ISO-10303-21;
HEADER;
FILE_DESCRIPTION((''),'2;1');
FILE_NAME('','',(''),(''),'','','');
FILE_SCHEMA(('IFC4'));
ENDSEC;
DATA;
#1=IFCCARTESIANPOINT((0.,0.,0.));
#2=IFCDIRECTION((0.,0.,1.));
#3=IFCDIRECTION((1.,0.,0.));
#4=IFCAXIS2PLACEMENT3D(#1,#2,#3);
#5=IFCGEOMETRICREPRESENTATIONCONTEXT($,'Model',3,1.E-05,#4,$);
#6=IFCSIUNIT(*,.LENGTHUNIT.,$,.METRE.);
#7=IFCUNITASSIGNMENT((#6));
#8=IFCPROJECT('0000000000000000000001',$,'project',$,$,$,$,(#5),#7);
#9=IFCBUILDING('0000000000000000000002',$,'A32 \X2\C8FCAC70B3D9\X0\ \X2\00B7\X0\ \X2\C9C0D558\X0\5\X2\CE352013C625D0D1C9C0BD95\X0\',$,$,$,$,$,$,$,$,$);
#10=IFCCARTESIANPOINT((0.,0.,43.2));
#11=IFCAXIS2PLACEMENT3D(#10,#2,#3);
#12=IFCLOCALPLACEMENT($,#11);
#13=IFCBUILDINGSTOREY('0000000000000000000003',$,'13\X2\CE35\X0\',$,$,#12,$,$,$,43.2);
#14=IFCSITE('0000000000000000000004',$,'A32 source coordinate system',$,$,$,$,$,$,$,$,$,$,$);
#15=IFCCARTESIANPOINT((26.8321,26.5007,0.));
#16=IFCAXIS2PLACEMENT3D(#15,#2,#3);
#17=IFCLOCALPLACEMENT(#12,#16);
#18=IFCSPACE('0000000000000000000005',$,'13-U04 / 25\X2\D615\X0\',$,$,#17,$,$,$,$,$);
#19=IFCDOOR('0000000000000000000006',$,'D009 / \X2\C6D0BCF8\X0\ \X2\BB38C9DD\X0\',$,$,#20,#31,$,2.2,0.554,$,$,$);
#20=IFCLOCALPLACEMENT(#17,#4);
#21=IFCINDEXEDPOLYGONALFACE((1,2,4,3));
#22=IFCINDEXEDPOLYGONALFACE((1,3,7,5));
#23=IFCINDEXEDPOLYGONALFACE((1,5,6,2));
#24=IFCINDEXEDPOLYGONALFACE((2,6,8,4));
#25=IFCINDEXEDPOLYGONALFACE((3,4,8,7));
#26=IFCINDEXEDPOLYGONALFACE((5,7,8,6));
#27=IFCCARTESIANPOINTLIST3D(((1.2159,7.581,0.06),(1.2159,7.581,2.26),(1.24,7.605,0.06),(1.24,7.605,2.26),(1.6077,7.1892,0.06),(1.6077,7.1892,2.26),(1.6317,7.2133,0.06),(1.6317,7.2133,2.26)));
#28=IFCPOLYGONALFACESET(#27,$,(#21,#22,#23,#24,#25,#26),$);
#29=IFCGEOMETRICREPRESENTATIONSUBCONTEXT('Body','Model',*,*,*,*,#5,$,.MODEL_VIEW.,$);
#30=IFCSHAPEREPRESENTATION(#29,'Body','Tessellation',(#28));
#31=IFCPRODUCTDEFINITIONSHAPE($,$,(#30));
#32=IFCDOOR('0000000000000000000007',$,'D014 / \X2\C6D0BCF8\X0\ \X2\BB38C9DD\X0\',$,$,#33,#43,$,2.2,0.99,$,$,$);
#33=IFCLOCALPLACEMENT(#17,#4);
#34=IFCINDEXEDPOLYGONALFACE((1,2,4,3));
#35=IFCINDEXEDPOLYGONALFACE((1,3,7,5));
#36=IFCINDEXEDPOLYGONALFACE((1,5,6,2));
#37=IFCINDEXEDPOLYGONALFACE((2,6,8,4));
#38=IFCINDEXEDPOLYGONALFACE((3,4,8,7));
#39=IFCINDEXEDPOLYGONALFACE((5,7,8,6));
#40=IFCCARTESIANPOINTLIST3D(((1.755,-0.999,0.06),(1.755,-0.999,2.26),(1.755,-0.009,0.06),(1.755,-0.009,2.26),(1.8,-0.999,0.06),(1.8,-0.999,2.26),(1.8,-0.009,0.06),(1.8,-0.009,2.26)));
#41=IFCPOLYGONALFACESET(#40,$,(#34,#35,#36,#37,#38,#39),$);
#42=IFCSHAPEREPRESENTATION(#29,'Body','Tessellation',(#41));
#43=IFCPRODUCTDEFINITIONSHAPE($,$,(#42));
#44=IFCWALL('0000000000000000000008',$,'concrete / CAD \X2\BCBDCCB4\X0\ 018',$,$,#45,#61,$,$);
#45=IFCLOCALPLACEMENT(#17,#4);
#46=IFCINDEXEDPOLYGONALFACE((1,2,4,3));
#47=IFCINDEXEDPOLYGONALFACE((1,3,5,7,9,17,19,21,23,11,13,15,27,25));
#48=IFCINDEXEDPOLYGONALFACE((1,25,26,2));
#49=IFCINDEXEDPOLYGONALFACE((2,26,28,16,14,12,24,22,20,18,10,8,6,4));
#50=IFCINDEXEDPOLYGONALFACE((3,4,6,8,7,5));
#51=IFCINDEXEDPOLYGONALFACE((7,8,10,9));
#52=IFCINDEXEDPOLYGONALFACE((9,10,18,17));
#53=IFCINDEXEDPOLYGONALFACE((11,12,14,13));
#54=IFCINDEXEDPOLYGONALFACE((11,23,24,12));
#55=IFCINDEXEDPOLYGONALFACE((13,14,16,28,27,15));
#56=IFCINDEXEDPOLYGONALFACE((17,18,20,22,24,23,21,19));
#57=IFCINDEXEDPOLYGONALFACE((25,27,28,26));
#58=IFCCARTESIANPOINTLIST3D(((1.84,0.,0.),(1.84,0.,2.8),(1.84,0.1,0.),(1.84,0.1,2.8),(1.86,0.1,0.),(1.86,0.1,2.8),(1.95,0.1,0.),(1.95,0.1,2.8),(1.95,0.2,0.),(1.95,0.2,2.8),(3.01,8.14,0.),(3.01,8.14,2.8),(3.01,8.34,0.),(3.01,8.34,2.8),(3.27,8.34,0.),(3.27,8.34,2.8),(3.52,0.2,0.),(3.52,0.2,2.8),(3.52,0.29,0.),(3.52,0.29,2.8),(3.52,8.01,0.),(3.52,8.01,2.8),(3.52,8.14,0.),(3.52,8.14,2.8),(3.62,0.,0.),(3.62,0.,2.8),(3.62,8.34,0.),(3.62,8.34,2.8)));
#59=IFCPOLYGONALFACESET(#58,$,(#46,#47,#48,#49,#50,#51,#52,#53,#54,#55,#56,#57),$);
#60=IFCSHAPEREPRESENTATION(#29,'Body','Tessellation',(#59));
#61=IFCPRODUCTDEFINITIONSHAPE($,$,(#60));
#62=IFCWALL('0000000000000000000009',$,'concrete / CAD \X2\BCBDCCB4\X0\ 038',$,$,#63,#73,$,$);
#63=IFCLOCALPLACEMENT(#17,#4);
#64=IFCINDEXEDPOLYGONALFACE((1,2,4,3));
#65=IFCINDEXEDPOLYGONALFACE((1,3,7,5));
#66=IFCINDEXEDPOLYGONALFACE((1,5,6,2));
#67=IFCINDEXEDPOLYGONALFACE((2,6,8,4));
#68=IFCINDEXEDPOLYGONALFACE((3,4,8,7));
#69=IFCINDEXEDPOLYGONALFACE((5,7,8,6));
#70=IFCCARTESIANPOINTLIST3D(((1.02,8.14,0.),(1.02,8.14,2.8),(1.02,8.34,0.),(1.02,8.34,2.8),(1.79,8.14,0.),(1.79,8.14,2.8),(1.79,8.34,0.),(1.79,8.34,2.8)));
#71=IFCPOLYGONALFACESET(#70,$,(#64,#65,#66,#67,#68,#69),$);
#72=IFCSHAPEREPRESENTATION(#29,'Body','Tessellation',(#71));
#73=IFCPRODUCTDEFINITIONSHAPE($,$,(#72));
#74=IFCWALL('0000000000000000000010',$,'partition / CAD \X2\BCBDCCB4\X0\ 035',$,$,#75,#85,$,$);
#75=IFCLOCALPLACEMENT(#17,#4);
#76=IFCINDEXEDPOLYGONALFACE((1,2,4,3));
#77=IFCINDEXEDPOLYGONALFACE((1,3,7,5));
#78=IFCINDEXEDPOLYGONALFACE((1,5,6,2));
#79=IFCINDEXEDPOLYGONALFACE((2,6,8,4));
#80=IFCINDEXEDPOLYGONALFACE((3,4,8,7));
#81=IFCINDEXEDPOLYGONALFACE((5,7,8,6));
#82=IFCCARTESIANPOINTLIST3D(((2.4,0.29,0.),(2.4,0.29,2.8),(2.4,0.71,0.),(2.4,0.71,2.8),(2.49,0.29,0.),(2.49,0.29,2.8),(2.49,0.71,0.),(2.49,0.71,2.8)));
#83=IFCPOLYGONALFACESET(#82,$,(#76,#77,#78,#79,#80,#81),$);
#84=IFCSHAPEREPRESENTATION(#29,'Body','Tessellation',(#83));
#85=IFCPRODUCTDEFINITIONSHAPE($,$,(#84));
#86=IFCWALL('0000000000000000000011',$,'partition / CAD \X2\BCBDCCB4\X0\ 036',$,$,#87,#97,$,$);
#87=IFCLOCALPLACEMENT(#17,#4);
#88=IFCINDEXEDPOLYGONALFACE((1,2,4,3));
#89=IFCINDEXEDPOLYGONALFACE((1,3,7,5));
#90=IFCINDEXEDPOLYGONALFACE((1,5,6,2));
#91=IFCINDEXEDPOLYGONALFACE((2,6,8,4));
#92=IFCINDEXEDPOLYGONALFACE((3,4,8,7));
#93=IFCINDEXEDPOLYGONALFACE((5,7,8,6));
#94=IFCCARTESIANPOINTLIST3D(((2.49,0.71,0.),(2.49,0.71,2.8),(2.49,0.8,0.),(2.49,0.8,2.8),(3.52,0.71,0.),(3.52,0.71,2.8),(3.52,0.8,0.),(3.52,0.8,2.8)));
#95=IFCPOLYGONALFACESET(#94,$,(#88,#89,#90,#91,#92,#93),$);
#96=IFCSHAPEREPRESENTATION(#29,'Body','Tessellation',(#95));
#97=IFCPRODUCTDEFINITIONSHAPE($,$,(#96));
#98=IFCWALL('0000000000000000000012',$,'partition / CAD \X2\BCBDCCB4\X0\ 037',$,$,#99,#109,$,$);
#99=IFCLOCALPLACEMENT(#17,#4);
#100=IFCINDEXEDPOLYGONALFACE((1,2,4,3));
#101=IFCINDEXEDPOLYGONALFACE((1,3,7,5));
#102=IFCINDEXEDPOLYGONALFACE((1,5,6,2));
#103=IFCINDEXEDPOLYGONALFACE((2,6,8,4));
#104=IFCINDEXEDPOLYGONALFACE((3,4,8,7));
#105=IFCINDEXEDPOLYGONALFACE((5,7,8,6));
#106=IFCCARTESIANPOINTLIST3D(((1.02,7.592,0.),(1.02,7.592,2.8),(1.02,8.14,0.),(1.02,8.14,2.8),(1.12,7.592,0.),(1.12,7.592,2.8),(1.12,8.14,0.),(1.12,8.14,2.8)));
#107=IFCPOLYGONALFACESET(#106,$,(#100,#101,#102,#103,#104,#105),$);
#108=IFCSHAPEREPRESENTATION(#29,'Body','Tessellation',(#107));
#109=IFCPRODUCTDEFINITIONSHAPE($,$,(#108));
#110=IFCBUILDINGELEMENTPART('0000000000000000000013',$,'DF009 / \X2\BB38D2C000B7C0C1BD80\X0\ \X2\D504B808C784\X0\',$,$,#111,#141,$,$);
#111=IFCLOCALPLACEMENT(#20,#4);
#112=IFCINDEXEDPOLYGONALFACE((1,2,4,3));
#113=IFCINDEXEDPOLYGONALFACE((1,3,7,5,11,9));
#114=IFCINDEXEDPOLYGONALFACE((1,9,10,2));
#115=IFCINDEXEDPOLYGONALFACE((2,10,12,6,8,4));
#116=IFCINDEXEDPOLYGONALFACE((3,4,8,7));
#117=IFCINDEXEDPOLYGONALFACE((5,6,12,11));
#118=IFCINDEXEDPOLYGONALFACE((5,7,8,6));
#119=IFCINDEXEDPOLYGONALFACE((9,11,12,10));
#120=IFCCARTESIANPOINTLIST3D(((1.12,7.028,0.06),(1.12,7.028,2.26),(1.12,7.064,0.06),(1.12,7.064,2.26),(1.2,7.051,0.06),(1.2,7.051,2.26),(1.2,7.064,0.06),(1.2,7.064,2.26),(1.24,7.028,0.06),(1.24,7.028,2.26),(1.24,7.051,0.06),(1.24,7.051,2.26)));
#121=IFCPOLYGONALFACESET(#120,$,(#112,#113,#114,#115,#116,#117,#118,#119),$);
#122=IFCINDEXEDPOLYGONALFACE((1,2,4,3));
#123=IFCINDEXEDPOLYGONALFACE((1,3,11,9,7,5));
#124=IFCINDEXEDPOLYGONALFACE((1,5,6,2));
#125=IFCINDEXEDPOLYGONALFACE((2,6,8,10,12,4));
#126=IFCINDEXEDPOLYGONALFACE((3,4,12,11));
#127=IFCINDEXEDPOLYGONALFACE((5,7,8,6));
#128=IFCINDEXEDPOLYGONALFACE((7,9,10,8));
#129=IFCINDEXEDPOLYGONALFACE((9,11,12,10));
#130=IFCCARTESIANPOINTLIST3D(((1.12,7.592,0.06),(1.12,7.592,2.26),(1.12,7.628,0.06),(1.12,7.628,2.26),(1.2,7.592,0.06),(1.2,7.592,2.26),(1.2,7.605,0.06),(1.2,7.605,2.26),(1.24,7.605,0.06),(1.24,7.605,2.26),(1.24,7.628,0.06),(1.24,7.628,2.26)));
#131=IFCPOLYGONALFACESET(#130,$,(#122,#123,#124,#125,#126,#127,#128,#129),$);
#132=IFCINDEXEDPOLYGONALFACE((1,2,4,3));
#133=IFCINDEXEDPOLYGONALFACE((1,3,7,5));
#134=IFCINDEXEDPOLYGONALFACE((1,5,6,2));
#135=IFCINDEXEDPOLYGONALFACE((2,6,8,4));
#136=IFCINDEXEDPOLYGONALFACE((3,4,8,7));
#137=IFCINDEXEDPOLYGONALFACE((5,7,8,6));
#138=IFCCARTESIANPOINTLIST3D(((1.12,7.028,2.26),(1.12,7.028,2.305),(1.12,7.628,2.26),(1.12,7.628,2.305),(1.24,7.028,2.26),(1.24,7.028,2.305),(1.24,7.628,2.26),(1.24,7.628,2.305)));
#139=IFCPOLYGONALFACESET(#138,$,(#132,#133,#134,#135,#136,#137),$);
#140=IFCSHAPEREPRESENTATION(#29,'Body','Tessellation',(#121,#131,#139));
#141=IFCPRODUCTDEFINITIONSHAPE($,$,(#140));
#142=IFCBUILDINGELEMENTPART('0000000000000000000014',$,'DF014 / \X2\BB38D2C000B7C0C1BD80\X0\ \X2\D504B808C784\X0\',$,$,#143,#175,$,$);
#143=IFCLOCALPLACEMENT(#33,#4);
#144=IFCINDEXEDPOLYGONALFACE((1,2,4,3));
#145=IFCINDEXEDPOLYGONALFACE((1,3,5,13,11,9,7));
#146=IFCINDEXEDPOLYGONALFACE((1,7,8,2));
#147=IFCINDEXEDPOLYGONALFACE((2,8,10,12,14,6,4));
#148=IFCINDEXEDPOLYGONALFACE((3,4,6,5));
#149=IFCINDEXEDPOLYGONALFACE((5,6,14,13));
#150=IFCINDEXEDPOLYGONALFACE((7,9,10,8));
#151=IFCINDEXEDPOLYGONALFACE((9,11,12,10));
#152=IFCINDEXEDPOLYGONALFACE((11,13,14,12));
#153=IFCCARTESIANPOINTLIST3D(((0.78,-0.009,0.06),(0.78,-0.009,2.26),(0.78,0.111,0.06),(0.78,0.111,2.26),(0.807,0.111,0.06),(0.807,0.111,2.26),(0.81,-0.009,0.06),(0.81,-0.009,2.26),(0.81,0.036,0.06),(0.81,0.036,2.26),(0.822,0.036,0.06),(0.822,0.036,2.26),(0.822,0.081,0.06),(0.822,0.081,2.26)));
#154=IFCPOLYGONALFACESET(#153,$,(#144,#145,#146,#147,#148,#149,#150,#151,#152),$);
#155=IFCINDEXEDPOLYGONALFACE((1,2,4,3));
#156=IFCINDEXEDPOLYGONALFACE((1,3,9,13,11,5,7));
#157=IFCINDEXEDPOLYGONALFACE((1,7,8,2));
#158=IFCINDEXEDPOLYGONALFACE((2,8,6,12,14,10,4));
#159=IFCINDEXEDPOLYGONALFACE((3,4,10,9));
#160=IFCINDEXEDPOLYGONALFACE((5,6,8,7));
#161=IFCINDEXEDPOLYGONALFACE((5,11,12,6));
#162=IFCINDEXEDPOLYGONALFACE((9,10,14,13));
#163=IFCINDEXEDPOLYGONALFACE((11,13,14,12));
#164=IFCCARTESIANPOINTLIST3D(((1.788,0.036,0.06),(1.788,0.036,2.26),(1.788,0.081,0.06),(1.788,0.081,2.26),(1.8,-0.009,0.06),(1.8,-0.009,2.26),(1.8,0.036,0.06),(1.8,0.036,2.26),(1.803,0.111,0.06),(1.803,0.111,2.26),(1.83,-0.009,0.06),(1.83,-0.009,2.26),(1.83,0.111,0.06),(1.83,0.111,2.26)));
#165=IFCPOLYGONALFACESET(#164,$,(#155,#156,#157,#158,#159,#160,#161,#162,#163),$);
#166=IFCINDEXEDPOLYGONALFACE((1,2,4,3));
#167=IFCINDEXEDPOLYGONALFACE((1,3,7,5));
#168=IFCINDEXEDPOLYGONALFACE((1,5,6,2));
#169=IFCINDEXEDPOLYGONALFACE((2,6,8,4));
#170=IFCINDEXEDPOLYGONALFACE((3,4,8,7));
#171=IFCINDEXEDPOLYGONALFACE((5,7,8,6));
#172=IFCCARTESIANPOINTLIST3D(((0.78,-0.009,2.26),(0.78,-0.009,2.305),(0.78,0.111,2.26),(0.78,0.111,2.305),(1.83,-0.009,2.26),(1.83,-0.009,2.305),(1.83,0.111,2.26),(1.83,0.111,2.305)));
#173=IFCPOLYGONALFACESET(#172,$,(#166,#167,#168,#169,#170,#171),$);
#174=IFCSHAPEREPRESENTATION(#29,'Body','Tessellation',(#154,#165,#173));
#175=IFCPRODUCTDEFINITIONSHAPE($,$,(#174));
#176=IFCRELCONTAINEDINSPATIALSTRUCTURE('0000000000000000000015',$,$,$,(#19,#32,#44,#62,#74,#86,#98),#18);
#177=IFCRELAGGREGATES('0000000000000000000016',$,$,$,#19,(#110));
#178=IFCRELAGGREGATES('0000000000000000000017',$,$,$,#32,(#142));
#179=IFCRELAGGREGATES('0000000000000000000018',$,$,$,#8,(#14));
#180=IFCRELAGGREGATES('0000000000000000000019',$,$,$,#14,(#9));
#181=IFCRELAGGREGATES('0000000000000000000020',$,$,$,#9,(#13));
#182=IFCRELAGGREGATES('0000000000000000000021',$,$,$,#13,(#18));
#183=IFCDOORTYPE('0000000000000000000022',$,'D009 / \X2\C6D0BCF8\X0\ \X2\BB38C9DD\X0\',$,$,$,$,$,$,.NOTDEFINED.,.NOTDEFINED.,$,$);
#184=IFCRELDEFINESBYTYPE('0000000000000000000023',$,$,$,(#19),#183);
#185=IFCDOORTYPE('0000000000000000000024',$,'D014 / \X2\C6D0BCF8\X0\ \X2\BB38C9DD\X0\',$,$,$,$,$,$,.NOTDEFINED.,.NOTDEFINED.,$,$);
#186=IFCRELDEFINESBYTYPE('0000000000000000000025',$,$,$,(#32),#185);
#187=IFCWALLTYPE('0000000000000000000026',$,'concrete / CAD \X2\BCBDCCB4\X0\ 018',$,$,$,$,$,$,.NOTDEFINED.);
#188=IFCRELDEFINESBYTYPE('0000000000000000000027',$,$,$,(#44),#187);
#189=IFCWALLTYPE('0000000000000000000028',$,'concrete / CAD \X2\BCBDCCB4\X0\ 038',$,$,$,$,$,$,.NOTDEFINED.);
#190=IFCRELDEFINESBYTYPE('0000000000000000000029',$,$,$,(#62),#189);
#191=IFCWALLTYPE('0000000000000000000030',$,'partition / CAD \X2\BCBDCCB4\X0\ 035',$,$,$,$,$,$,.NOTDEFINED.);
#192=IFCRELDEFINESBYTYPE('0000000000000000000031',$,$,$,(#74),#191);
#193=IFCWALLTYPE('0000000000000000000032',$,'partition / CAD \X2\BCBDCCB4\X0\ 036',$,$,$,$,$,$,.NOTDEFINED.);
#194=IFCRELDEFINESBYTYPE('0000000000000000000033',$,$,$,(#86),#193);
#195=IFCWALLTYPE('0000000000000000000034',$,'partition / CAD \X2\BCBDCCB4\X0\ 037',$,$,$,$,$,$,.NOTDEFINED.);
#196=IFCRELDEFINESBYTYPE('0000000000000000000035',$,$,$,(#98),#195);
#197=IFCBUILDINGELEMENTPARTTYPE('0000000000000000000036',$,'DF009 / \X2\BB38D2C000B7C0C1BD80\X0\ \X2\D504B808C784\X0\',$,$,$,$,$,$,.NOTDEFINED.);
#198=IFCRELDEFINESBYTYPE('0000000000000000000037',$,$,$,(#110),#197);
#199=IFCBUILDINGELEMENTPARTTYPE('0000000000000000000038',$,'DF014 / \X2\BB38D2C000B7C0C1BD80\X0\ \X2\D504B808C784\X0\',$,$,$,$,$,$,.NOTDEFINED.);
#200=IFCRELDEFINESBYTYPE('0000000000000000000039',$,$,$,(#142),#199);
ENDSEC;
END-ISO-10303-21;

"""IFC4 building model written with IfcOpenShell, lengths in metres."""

from ifc_helpers import new_model, si_unit, frame, origin, origin_with_axes, place, context, subcontext, project, spatial, polyline, outline, extrude, source, transform, mapped, type_object, type_shapes, element, aggregate, save


model = new_model("IFC4")

# Units and contexts
model_context = context("Model", 3, precision=1e-05, world=origin_with_axes())
body_context = subcontext(model_context, "Body", "Model", "MODEL_VIEW")
ifc_project = project(units=[si_unit("LENGTHUNIT", "METRE")], contexts=[model_context])

# Site, building, storey, space
storey_placement = place(None, frame((0.0, 0.0, 43.2), z_axis=(0.0, 0.0, 1.0), x_axis=(1.0, 0.0, 0.0)))
space_placement = place(storey_placement, frame((26.8321, 26.5007, 0.0), z_axis=(0.0, 0.0, 1.0), x_axis=(1.0, 0.0, 0.0)))
site = spatial("IfcSite", under=ifc_project, Name="A32 source coordinate system")
building = spatial("IfcBuilding", under=site, Name="A32 주거동 · 지하5층–옥탑지붕")
storey = spatial("IfcBuildingStorey", under=building, at=storey_placement, Name="13층", Elevation=43.2)
space = spatial("IfcSpace", under=storey, at=space_placement, Name="13-U04 / 25형")

# Doors
door_type_1 = type_object("IfcDoorType", Name="D009 / 원본 문짝", OperationType="NOTDEFINED", PredefinedType="NOTDEFINED")
shared_shape_1 = source(origin(), body_context, "Body", "SweptSolid", [
    extrude(outline(polyline([(1.24, 7.605), (1.6317, 7.2133), (1.6077, 7.1892), (1.2159, 7.581), (1.24, 7.605)])), frame((0.0, 0.0, 0.06)), (0.0, 0.0, 1.0), 2.2),
])
type_shapes(door_type_1, [shared_shape_1])
door_1_placement = place(space_placement, origin_with_axes())
door_1 = element("IfcDoor", 1, at=door_1_placement, inside=space, type_object=door_type_1, Name="D009 / 원본 문짝", OverallHeight=2.2, OverallWidth=0.554, context=body_context, shape_type="MappedRepresentation", body=[
    mapped(shared_shape_1, transform((0.0, 0.0, 0.0), scale=1.0)),
])
door_type_2 = type_object("IfcDoorType", Name="D014 / 원본 문짝", OperationType="NOTDEFINED", PredefinedType="NOTDEFINED")
shared_shape_2 = source(origin(), body_context, "Body", "SweptSolid", [
    extrude(outline(polyline([(1.8, -0.009), (1.8, -0.999), (1.755, -0.999), (1.755, -0.009), (1.8, -0.009)])), frame((0.0, 0.0, 0.06)), (0.0, 0.0, 1.0), 2.2),
])
type_shapes(door_type_2, [shared_shape_2])
door_2_placement = place(space_placement, origin_with_axes())
door_2 = element("IfcDoor", 2, at=door_2_placement, inside=space, type_object=door_type_2, Name="D014 / 원본 문짝", OverallHeight=2.2, OverallWidth=0.99, context=body_context, shape_type="MappedRepresentation", body=[
    mapped(shared_shape_2, transform((0.0, 0.0, 0.0), scale=1.0)),
])

# Walls
wall_type_1 = type_object("IfcWallType", Name="concrete / CAD 벽체 018", PredefinedType="NOTDEFINED")
shared_shape_3 = source(origin(), body_context, "Body", "SweptSolid", [
    extrude(outline(polyline([(3.27, 8.34), (3.27, 8.34), (3.62, 8.34), (3.62, 0.0), (1.84, 0.0), (1.84, 0.1), (1.86, 0.1), (1.95, 0.1), (1.95, 0.2), (3.52, 0.2), (3.52, 0.29), (3.52, 8.01), (3.52, 8.14), (3.01, 8.14), (3.01, 8.34), (3.27, 8.34)])), origin(), (0.0, 0.0, 1.0), 2.8),
])
type_shapes(wall_type_1, [shared_shape_3])
wall_1_placement = place(space_placement, origin_with_axes())
element("IfcWall", 3, at=wall_1_placement, inside=space, type_object=wall_type_1, Name="concrete / CAD 벽체 018", context=body_context, shape_type="MappedRepresentation", body=[
    mapped(shared_shape_3, transform((0.0, 0.0, 0.0), scale=1.0)),
])
wall_type_2 = type_object("IfcWallType", Name="concrete / CAD 벽체 038", PredefinedType="NOTDEFINED")
shared_shape_4 = source(origin(), body_context, "Body", "SweptSolid", [
    extrude(outline(polyline([(1.02, 8.14), (1.02, 8.34), (1.79, 8.34), (1.79, 8.14), (1.02, 8.14)])), origin(), (0.0, 0.0, 1.0), 2.8),
])
type_shapes(wall_type_2, [shared_shape_4])
wall_2_placement = place(space_placement, origin_with_axes())
element("IfcWall", 4, at=wall_2_placement, inside=space, type_object=wall_type_2, Name="concrete / CAD 벽체 038", context=body_context, shape_type="MappedRepresentation", body=[
    mapped(shared_shape_4, transform((0.0, 0.0, 0.0), scale=1.0)),
])
wall_type_3 = type_object("IfcWallType", Name="partition / CAD 벽체 035", PredefinedType="NOTDEFINED")
shared_shape_5 = source(origin(), body_context, "Body", "SweptSolid", [
    extrude(outline(polyline([(2.49, 0.71), (2.49, 0.29), (2.4, 0.29), (2.4, 0.71), (2.49, 0.71)])), origin(), (0.0, 0.0, 1.0), 2.8),
])
type_shapes(wall_type_3, [shared_shape_5])
wall_3_placement = place(space_placement, origin_with_axes())
element("IfcWall", 5, at=wall_3_placement, inside=space, type_object=wall_type_3, Name="partition / CAD 벽체 035", context=body_context, shape_type="MappedRepresentation", body=[
    mapped(shared_shape_5, transform((0.0, 0.0, 0.0), scale=1.0)),
])
wall_type_4 = type_object("IfcWallType", Name="partition / CAD 벽체 036", PredefinedType="NOTDEFINED")
shared_shape_6 = source(origin(), body_context, "Body", "SweptSolid", [
    extrude(outline(polyline([(2.49, 0.8), (3.52, 0.8), (3.52, 0.71), (2.49, 0.71), (2.49, 0.8)])), origin(), (0.0, 0.0, 1.0), 2.8),
])
type_shapes(wall_type_4, [shared_shape_6])
wall_4_placement = place(space_placement, origin_with_axes())
element("IfcWall", 6, at=wall_4_placement, inside=space, type_object=wall_type_4, Name="partition / CAD 벽체 036", context=body_context, shape_type="MappedRepresentation", body=[
    mapped(shared_shape_6, transform((0.0, 0.0, 0.0), scale=1.0)),
])
wall_type_5 = type_object("IfcWallType", Name="partition / CAD 벽체 037", PredefinedType="NOTDEFINED")
shared_shape_7 = source(origin(), body_context, "Body", "SweptSolid", [
    extrude(outline(polyline([(1.02, 7.592), (1.02, 8.14), (1.12, 8.14), (1.12, 7.592), (1.02, 7.592)])), origin(), (0.0, 0.0, 1.0), 2.8),
])
type_shapes(wall_type_5, [shared_shape_7])
wall_5_placement = place(space_placement, origin_with_axes())
element("IfcWall", 7, at=wall_5_placement, inside=space, type_object=wall_type_5, Name="partition / CAD 벽체 037", context=body_context, shape_type="MappedRepresentation", body=[
    mapped(shared_shape_7, transform((0.0, 0.0, 0.0), scale=1.0)),
])

# Building element parts
building_element_part_type_1 = type_object("IfcBuildingElementPartType", Name="DF009 / 문틀·상부 프레임", PredefinedType="NOTDEFINED")
shared_shape_8 = source(origin(), body_context, "Body", "SweptSolid", [
    extrude(outline(polyline([(1.12, 7.064), (1.2, 7.064), (1.2, 7.051), (1.24, 7.051), (1.24, 7.028), (1.12, 7.028), (1.12, 7.064)])), frame((0.0, 0.0, 0.06)), (0.0, 0.0, 1.0), 2.2),
    extrude(outline(polyline([(1.24, 7.628), (1.24, 7.605), (1.2, 7.605), (1.2, 7.592), (1.12, 7.592), (1.12, 7.628), (1.24, 7.628)])), frame((0.0, 0.0, 0.06)), (0.0, 0.0, 1.0), 2.2),
    extrude(outline(polyline([(1.12, 7.028), (1.12, 7.628), (1.24, 7.628), (1.24, 7.028), (1.12, 7.028)])), frame((0.0, 0.0, 2.26)), (0.0, 0.0, 1.0), 0.045),
])
type_shapes(building_element_part_type_1, [shared_shape_8])
building_element_part_1_placement = place(door_1_placement, origin_with_axes())
building_element_part_1 = element("IfcBuildingElementPart", 8, at=building_element_part_1_placement, type_object=building_element_part_type_1, Name="DF009 / 문틀·상부 프레임", context=body_context, shape_type="MappedRepresentation", body=[
    mapped(shared_shape_8, transform((0.0, 0.0, 0.0), scale=1.0)),
])
aggregate(door_1, [building_element_part_1])
building_element_part_type_2 = type_object("IfcBuildingElementPartType", Name="DF014 / 문틀·상부 프레임", PredefinedType="NOTDEFINED")
shared_shape_9 = source(origin(), body_context, "Body", "SweptSolid", [
    extrude(outline(polyline([(0.78, 0.111), (0.807, 0.111), (0.822, 0.081), (0.822, 0.036), (0.81, 0.036), (0.81, -0.009), (0.78, -0.009), (0.78, 0.111)])), frame((0.0, 0.0, 0.06)), (0.0, 0.0, 1.0), 2.2),
    extrude(outline(polyline([(1.8, -0.009), (1.8, 0.036), (1.788, 0.036), (1.788, 0.081), (1.803, 0.111), (1.83, 0.111), (1.83, -0.009), (1.8, -0.009)])), frame((0.0, 0.0, 0.06)), (0.0, 0.0, 1.0), 2.2),
    extrude(outline(polyline([(0.78, -0.009), (0.78, 0.111), (1.83, 0.111), (1.83, -0.009), (0.78, -0.009)])), frame((0.0, 0.0, 2.26)), (0.0, 0.0, 1.0), 0.045),
])
type_shapes(building_element_part_type_2, [shared_shape_9])
building_element_part_2_placement = place(door_2_placement, origin_with_axes())
building_element_part_2 = element("IfcBuildingElementPart", 9, at=building_element_part_2_placement, type_object=building_element_part_type_2, Name="DF014 / 문틀·상부 프레임", context=body_context, shape_type="MappedRepresentation", body=[
    mapped(shared_shape_9, transform((0.0, 0.0, 0.0), scale=1.0)),
])
aggregate(door_2, [building_element_part_2])

save(model, "model.ifc")
